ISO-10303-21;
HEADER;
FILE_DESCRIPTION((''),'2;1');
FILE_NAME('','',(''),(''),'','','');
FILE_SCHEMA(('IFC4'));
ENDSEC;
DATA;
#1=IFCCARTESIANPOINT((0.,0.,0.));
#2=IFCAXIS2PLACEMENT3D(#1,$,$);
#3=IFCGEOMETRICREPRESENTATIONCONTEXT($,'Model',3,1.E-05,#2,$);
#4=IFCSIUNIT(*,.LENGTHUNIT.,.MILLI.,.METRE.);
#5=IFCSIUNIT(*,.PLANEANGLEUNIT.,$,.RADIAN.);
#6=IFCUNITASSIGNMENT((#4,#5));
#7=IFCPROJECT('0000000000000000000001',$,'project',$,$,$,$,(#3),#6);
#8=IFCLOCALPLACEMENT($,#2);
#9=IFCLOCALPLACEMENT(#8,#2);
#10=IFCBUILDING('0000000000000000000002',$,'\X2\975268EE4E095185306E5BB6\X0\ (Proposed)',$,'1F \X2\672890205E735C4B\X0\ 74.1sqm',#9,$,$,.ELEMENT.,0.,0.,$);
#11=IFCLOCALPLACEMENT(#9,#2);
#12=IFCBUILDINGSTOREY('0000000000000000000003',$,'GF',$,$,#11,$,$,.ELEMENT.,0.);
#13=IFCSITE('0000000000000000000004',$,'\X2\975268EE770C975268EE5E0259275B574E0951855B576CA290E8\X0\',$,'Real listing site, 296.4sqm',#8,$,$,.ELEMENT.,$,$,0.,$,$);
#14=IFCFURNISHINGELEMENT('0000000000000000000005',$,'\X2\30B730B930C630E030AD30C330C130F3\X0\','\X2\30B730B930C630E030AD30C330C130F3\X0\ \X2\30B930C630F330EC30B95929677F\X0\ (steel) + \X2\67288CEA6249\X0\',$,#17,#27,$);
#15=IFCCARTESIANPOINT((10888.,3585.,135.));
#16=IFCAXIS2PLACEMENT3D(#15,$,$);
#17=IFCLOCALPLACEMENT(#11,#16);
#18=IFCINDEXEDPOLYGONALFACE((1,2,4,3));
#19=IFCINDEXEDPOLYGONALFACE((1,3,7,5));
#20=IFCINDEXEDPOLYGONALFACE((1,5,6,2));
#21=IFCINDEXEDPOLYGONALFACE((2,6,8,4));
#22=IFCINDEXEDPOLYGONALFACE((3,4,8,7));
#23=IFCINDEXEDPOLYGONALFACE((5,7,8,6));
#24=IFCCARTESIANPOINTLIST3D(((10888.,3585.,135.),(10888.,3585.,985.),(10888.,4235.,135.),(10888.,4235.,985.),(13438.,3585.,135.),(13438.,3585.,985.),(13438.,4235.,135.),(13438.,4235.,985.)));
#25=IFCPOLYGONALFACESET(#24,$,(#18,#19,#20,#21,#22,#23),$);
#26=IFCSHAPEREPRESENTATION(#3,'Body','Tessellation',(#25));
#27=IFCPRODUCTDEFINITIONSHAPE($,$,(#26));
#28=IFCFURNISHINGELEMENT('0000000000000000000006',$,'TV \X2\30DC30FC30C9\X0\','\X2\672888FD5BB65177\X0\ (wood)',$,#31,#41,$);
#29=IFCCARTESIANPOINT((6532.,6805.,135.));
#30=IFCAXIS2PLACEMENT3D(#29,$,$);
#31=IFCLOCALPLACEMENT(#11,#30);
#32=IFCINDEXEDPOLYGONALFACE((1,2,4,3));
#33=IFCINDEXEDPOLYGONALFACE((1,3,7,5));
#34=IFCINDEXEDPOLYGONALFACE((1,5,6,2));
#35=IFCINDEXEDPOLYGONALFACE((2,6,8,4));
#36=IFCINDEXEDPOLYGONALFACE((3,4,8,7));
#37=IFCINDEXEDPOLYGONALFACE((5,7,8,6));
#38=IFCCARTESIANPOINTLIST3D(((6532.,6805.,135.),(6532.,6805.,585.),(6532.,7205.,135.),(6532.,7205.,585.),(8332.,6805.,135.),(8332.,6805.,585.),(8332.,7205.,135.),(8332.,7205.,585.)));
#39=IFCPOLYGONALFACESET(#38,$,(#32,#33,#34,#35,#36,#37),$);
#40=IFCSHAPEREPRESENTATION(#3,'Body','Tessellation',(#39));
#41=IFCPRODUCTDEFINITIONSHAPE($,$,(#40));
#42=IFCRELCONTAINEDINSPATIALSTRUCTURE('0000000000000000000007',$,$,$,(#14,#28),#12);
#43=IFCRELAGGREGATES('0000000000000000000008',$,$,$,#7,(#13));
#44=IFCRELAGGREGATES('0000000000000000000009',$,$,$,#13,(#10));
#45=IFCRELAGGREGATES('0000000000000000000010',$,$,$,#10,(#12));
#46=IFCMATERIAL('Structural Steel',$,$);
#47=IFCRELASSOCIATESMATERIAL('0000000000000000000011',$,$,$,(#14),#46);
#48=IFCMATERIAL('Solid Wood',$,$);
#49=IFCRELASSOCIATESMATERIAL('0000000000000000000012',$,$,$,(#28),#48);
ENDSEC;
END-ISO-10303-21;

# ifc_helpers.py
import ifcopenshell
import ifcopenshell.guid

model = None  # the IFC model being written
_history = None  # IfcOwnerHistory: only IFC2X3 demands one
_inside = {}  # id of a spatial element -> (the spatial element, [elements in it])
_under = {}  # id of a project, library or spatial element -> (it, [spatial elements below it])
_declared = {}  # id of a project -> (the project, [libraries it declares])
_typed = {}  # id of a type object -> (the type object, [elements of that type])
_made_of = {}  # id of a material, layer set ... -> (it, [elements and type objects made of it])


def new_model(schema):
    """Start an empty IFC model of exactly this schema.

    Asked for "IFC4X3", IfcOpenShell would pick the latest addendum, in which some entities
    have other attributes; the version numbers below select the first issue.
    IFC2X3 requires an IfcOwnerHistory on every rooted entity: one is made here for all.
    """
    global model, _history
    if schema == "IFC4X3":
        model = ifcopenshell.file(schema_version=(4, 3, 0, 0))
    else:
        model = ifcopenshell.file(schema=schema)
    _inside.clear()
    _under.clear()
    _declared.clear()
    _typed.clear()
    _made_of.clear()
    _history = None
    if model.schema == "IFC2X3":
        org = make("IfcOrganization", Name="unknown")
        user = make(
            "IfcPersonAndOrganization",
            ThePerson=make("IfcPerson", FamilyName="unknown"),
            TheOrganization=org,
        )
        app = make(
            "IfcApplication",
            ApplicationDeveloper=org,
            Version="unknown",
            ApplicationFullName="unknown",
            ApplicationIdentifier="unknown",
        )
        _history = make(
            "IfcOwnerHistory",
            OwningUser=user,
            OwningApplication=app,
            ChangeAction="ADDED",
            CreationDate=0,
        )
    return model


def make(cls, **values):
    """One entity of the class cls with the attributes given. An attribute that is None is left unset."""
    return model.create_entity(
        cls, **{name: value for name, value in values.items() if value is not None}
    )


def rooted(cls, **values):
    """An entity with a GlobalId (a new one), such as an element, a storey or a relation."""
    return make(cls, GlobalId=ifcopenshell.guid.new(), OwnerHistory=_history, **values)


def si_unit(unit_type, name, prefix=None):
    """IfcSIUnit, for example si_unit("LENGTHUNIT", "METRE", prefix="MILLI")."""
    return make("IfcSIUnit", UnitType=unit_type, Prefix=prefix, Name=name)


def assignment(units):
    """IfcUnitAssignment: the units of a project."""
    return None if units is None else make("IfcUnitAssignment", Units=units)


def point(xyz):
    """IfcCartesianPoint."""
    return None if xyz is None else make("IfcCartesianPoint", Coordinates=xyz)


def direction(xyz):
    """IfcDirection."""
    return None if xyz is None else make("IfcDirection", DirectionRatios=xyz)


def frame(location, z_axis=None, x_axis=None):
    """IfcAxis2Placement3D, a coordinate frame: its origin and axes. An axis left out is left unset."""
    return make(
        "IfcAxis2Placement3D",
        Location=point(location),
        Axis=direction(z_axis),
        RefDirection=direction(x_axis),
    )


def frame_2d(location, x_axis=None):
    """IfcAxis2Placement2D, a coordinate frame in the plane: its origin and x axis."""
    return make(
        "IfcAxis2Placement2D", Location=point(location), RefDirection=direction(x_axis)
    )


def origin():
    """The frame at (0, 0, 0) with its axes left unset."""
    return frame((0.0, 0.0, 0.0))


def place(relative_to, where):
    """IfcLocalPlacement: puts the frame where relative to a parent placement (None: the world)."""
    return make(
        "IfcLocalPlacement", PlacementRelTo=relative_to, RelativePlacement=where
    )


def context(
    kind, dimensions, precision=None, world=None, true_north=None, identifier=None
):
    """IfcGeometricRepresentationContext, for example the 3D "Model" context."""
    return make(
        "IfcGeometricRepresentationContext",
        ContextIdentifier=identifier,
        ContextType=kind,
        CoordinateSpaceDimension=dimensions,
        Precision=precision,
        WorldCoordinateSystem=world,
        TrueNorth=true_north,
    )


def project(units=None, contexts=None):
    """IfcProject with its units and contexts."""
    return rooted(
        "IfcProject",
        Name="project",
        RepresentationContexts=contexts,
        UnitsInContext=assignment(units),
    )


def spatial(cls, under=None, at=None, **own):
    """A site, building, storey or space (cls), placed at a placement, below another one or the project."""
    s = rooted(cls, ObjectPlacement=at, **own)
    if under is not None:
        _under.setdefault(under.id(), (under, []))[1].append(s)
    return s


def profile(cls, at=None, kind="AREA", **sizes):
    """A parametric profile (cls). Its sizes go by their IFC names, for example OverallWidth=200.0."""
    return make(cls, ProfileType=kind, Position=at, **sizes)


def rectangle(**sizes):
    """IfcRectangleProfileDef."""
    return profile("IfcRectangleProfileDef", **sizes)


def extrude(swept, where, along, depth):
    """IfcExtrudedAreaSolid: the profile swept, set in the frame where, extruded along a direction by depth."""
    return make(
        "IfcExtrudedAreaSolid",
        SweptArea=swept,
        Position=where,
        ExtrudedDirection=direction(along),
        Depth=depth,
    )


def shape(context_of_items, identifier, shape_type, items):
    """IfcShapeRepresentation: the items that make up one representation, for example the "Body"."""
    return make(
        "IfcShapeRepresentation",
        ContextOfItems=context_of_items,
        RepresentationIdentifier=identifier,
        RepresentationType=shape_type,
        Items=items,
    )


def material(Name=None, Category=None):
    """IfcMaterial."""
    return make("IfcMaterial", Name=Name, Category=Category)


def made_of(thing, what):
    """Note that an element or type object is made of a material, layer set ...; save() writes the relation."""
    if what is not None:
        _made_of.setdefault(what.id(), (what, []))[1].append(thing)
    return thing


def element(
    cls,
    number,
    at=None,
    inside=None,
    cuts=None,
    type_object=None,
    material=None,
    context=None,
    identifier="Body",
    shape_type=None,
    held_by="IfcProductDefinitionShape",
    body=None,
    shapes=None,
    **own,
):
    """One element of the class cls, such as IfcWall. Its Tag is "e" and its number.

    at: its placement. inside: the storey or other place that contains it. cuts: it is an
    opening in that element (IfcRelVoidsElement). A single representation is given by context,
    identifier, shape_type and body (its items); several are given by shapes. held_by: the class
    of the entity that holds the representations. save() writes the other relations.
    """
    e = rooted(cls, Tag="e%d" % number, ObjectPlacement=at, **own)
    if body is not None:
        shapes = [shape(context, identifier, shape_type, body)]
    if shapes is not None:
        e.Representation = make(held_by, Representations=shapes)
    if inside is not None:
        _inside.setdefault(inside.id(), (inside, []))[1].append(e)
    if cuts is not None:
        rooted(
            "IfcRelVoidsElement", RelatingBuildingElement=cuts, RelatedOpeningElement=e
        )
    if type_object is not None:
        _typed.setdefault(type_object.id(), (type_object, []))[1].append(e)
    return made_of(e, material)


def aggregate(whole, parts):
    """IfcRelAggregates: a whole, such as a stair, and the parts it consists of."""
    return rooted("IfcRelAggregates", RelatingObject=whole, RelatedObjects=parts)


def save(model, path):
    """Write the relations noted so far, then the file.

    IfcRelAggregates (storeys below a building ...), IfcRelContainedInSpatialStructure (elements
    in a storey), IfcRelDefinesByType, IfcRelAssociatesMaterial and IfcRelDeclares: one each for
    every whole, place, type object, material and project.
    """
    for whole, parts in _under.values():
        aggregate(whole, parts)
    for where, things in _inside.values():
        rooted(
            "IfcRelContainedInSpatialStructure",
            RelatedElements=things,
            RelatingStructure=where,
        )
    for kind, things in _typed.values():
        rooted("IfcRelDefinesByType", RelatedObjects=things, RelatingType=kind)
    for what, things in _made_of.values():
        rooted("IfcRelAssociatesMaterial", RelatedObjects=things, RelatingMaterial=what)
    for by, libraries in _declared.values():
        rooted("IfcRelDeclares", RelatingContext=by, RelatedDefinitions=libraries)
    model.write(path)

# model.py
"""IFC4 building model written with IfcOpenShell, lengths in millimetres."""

from ifc_helpers import new_model, si_unit, frame, frame_2d, origin, place, context, project, spatial, rectangle, extrude, material, element, save


model = new_model("IFC4")

# Units and contexts
model_context = context("Model", 3, precision=1e-05, world=origin())
ifc_project = project(units=[si_unit("LENGTHUNIT", "METRE", prefix="MILLI"), si_unit("PLANEANGLEUNIT", "RADIAN")], contexts=[model_context])

# Site, building, storey
site_placement = place(None, origin())
site = spatial("IfcSite", under=ifc_project, at=site_placement, Name="青森県青森市大字三内字沢部", ObjectType="Real listing site, 296.4sqm", CompositionType="ELEMENT", RefElevation=0.0)
building_placement = place(site_placement, origin())
building = spatial("IfcBuilding", under=site, at=building_placement, Name="青森三内の家 (Proposed)", ObjectType="1F 木造平屋 74.1sqm", CompositionType="ELEMENT", ElevationOfRefHeight=0.0, ElevationOfTerrain=0.0)
storey_placement = place(building_placement, origin())
storey = spatial("IfcBuildingStorey", under=building, at=storey_placement, Name="GF", CompositionType="ELEMENT", Elevation=0.0)

# Shared definitions
ifc_material_1 = material(Name="Solid Wood")

# Furnishing elements
ifc_material_2 = material(Name="Structural Steel")
furnishing_1_placement = place(storey_placement, frame((10888.0, 3585.0, 135.0)))
element("IfcFurnishingElement", 1, at=furnishing_1_placement, inside=storey, material=ifc_material_2, Name="システムキッチン", Description="システムキッチン ステンレス天板 (steel) + 木質扉", context=model_context, shape_type="SweptSolid", body=[
    extrude(rectangle(XDim=2550.0, YDim=650.0, at=frame_2d((1275.0, 325.0))), frame((10888.0, 3585.0, 135.0)), (0.0, 0.0, 1.0), 850.0),
])
furnishing_2_placement = place(storey_placement, frame((6532.0, 6805.0, 135.0)))
element("IfcFurnishingElement", 2, at=furnishing_2_placement, inside=storey, material=ifc_material_1, Name="TV ボード", Description="木製家具 (wood)", context=model_context, shape_type="SweptSolid", body=[
    extrude(rectangle(XDim=1800.0, YDim=400.0, at=frame_2d((900.0, 200.0))), frame((6532.0, 6805.0, 135.0)), (0.0, 0.0, 1.0), 450.0),
])

save(model, "model.ifc")
